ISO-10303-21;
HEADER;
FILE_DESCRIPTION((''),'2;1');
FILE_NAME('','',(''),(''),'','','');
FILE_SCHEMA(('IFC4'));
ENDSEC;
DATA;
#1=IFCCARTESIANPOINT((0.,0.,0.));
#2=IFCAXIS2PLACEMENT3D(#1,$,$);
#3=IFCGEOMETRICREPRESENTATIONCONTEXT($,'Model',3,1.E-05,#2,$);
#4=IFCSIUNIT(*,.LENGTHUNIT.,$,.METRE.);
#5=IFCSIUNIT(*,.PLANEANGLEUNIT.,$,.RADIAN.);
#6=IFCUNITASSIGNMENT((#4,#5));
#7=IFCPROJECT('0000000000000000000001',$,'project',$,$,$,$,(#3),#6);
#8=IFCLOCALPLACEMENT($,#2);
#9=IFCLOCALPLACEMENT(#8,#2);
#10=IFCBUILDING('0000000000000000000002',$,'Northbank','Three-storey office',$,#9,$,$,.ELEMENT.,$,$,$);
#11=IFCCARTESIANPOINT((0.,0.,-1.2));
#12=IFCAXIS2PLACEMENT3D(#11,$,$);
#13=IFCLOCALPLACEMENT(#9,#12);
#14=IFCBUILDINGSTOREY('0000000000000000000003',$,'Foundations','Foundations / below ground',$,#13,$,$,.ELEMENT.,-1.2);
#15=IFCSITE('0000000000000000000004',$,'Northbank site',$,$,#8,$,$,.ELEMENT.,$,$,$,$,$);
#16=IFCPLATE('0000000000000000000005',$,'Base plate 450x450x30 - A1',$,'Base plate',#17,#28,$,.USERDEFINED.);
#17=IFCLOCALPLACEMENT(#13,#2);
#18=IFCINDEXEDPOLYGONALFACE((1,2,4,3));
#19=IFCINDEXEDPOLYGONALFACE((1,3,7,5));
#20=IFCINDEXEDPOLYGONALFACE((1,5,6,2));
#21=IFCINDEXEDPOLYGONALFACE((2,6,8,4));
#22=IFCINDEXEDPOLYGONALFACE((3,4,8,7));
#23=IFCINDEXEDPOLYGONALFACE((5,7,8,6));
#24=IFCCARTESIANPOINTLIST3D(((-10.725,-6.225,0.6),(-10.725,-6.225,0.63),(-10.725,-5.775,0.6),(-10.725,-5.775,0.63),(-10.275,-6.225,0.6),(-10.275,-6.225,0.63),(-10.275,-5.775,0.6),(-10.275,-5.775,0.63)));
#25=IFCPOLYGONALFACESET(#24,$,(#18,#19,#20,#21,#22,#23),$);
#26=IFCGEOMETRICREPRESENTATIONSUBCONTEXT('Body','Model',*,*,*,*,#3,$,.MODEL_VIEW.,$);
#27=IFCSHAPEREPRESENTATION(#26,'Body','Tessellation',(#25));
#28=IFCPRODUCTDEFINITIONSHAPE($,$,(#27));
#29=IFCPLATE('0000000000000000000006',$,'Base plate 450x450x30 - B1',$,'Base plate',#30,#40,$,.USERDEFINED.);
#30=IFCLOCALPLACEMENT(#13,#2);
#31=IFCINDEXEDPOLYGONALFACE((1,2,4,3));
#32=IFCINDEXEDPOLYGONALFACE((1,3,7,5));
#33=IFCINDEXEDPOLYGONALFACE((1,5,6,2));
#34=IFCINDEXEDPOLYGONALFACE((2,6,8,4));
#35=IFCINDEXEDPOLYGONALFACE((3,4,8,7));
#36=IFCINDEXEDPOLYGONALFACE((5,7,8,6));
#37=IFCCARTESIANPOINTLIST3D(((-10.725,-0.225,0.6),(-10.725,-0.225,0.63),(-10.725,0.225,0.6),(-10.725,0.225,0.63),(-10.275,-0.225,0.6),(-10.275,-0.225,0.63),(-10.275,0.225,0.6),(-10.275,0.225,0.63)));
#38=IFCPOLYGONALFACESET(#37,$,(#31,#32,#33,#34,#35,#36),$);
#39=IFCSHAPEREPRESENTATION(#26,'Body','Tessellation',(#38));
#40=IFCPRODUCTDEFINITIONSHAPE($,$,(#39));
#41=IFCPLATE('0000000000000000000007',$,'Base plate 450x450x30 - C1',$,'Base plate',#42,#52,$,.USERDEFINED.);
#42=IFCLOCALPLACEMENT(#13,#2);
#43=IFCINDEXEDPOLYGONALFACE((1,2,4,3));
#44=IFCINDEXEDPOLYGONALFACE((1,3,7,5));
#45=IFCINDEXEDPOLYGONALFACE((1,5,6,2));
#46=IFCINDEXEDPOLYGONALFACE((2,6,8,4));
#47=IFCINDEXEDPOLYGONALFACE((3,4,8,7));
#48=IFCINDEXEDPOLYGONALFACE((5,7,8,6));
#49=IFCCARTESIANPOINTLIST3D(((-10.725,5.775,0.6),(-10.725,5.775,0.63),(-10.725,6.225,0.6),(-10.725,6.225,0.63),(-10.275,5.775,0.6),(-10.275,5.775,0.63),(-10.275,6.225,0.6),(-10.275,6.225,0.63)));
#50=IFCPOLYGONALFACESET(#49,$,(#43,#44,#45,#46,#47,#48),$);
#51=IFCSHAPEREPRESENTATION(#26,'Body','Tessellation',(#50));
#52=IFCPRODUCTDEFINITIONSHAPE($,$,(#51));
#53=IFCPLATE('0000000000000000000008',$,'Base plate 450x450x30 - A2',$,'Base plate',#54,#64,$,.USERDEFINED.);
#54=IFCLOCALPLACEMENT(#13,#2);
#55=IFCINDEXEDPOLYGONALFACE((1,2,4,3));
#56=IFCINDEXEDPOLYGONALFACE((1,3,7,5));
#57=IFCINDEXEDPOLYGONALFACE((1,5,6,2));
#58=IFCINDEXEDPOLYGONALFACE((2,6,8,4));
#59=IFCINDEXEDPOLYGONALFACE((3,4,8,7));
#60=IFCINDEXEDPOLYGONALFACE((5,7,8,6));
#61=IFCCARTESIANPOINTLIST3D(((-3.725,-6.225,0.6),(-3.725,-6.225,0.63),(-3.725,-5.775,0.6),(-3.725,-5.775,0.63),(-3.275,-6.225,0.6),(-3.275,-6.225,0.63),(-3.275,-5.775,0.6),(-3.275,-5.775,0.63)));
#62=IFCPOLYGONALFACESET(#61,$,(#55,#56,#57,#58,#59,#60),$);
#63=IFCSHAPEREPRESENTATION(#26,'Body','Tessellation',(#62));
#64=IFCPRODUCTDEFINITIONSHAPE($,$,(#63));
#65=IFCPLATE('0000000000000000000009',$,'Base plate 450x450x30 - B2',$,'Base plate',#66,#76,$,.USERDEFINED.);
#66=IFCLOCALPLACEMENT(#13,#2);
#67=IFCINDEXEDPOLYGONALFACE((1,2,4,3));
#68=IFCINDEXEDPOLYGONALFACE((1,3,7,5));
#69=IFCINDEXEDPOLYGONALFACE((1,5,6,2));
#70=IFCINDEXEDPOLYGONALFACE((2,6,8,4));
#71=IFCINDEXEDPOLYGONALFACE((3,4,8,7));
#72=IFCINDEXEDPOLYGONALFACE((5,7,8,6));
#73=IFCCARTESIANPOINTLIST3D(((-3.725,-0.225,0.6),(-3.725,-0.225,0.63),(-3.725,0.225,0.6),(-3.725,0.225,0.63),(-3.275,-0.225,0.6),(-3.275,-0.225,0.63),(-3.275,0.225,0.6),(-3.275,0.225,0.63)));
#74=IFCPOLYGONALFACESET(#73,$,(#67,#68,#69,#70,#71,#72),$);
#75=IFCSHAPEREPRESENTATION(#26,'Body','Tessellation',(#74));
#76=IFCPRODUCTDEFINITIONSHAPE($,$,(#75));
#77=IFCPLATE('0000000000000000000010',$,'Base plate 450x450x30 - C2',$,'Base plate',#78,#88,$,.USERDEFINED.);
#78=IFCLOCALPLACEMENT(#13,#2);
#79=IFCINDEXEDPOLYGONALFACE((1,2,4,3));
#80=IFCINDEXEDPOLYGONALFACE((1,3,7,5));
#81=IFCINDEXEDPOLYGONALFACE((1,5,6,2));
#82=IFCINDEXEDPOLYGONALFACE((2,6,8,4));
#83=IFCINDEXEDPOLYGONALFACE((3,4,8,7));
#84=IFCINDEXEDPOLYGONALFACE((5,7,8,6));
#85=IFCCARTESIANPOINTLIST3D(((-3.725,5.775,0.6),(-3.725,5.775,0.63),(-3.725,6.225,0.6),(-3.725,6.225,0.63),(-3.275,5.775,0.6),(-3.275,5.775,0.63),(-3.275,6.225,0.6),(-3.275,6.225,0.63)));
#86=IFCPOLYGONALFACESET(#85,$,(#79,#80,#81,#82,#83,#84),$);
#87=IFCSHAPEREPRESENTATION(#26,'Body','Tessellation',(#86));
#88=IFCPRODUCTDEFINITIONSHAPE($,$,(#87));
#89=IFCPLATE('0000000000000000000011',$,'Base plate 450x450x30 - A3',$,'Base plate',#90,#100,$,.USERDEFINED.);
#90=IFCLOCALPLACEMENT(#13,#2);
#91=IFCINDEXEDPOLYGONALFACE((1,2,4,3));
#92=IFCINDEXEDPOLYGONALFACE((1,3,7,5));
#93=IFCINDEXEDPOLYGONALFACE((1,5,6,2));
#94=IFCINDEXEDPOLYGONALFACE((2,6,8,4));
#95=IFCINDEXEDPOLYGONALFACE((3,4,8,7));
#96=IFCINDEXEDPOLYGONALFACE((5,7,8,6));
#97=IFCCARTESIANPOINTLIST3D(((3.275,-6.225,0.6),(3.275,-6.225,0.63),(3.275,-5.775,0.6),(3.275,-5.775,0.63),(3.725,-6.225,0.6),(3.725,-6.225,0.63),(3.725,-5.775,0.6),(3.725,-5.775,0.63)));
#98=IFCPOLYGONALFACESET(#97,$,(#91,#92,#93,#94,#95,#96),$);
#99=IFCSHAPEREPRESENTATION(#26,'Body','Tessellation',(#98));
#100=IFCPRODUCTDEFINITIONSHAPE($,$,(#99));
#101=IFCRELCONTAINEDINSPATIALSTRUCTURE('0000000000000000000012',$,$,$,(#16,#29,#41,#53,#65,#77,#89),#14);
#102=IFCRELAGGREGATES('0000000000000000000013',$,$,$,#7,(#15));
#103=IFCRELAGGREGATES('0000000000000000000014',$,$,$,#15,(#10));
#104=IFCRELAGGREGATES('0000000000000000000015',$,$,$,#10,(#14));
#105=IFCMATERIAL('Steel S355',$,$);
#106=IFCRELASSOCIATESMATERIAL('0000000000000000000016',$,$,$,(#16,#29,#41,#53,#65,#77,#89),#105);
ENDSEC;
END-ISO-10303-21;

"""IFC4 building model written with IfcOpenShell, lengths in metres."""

from ifc_helpers import new_model, si_unit, frame, origin, place, context, subcontext, project, spatial, rectangle, extrude, material, element, save


model = new_model("IFC4")

# Units and contexts
model_context = context("Model", 3, precision=1e-05, world=origin())
body_context = subcontext(model_context, "Body", "Model", "MODEL_VIEW")
ifc_project = project(units=[si_unit("LENGTHUNIT", "METRE"), si_unit("PLANEANGLEUNIT", "RADIAN")], contexts=[model_context])

# Site, building, storey
site_placement = place(None, origin())
site = spatial("IfcSite", under=ifc_project, at=site_placement, Name="Northbank site", CompositionType="ELEMENT")
building_placement = place(site_placement, origin())
building = spatial("IfcBuilding", under=site, at=building_placement, Name="Northbank", Description="Three-storey office", CompositionType="ELEMENT")
storey_placement = place(building_placement, frame((0.0, 0.0, -1.2)))
storey = spatial("IfcBuildingStorey", under=building, at=storey_placement, Name="Foundations", Description="Foundations / below ground", CompositionType="ELEMENT", Elevation=-1.2)

# Plates
ifc_material_1 = material(Name="Steel S355")
plate_1_placement = place(storey_placement, frame((0.0, 0.0, 1.2)))
element("IfcPlate", 1, at=plate_1_placement, inside=storey, material=ifc_material_1, Name="Base plate 450x450x30 - A1", ObjectType="Base plate", PredefinedType="USERDEFINED", context=body_context, shape_type="SweptSolid", body=[
    extrude(rectangle(XDim=0.45, YDim=0.45), frame((-10.5, -6.0, -0.6)), (0.0, 0.0, 1.0), 0.03),
])
plate_2_placement = place(storey_placement, frame((0.0, 0.0, 1.2)))
element("IfcPlate", 2, at=plate_2_placement, inside=storey, material=ifc_material_1, Name="Base plate 450x450x30 - B1", ObjectType="Base plate", PredefinedType="USERDEFINED", context=body_context, shape_type="SweptSolid", body=[
    extrude(rectangle(XDim=0.45, YDim=0.45), frame((-10.5, 0.0, -0.6)), (0.0, 0.0, 1.0), 0.03),
])
plate_3_placement = place(storey_placement, frame((0.0, 0.0, 1.2)))
element("IfcPlate", 3, at=plate_3_placement, inside=storey, material=ifc_material_1, Name="Base plate 450x450x30 - C1", ObjectType="Base plate", PredefinedType="USERDEFINED", context=body_context, shape_type="SweptSolid", body=[
    extrude(rectangle(XDim=0.45, YDim=0.45), frame((-10.5, 6.0, -0.6)), (0.0, 0.0, 1.0), 0.03),
])
plate_4_placement = place(storey_placement, frame((0.0, 0.0, 1.2)))
element("IfcPlate", 4, at=plate_4_placement, inside=storey, material=ifc_material_1, Name="Base plate 450x450x30 - A2", ObjectType="Base plate", PredefinedType="USERDEFINED", context=body_context, shape_type="SweptSolid", body=[
    extrude(rectangle(XDim=0.45, YDim=0.45), frame((-3.5, -6.0, -0.6)), (0.0, 0.0, 1.0), 0.03),
])
plate_5_placement = place(storey_placement, frame((0.0, 0.0, 1.2)))
element("IfcPlate", 5, at=plate_5_placement, inside=storey, material=ifc_material_1, Name="Base plate 450x450x30 - B2", ObjectType="Base plate", PredefinedType="USERDEFINED", context=body_context, shape_type="SweptSolid", body=[
    extrude(rectangle(XDim=0.45, YDim=0.45), frame((-3.5, 0.0, -0.6)), (0.0, 0.0, 1.0), 0.03),
])
plate_6_placement = place(storey_placement, frame((0.0, 0.0, 1.2)))
element("IfcPlate", 6, at=plate_6_placement, inside=storey, material=ifc_material_1, Name="Base plate 450x450x30 - C2", ObjectType="Base plate", PredefinedType="USERDEFINED", context=body_context, shape_type="SweptSolid", body=[
    extrude(rectangle(XDim=0.45, YDim=0.45), frame((-3.5, 6.0, -0.6)), (0.0, 0.0, 1.0), 0.03),
])
plate_7_placement = place(storey_placement, frame((0.0, 0.0, 1.2)))
element("IfcPlate", 7, at=plate_7_placement, inside=storey, material=ifc_material_1, Name="Base plate 450x450x30 - A3", ObjectType="Base plate", PredefinedType="USERDEFINED", context=body_context, shape_type="SweptSolid", body=[
    extrude(rectangle(XDim=0.45, YDim=0.45), frame((3.5, -6.0, -0.6)), (0.0, 0.0, 1.0), 0.03),
])

save(model, "model.ifc")
